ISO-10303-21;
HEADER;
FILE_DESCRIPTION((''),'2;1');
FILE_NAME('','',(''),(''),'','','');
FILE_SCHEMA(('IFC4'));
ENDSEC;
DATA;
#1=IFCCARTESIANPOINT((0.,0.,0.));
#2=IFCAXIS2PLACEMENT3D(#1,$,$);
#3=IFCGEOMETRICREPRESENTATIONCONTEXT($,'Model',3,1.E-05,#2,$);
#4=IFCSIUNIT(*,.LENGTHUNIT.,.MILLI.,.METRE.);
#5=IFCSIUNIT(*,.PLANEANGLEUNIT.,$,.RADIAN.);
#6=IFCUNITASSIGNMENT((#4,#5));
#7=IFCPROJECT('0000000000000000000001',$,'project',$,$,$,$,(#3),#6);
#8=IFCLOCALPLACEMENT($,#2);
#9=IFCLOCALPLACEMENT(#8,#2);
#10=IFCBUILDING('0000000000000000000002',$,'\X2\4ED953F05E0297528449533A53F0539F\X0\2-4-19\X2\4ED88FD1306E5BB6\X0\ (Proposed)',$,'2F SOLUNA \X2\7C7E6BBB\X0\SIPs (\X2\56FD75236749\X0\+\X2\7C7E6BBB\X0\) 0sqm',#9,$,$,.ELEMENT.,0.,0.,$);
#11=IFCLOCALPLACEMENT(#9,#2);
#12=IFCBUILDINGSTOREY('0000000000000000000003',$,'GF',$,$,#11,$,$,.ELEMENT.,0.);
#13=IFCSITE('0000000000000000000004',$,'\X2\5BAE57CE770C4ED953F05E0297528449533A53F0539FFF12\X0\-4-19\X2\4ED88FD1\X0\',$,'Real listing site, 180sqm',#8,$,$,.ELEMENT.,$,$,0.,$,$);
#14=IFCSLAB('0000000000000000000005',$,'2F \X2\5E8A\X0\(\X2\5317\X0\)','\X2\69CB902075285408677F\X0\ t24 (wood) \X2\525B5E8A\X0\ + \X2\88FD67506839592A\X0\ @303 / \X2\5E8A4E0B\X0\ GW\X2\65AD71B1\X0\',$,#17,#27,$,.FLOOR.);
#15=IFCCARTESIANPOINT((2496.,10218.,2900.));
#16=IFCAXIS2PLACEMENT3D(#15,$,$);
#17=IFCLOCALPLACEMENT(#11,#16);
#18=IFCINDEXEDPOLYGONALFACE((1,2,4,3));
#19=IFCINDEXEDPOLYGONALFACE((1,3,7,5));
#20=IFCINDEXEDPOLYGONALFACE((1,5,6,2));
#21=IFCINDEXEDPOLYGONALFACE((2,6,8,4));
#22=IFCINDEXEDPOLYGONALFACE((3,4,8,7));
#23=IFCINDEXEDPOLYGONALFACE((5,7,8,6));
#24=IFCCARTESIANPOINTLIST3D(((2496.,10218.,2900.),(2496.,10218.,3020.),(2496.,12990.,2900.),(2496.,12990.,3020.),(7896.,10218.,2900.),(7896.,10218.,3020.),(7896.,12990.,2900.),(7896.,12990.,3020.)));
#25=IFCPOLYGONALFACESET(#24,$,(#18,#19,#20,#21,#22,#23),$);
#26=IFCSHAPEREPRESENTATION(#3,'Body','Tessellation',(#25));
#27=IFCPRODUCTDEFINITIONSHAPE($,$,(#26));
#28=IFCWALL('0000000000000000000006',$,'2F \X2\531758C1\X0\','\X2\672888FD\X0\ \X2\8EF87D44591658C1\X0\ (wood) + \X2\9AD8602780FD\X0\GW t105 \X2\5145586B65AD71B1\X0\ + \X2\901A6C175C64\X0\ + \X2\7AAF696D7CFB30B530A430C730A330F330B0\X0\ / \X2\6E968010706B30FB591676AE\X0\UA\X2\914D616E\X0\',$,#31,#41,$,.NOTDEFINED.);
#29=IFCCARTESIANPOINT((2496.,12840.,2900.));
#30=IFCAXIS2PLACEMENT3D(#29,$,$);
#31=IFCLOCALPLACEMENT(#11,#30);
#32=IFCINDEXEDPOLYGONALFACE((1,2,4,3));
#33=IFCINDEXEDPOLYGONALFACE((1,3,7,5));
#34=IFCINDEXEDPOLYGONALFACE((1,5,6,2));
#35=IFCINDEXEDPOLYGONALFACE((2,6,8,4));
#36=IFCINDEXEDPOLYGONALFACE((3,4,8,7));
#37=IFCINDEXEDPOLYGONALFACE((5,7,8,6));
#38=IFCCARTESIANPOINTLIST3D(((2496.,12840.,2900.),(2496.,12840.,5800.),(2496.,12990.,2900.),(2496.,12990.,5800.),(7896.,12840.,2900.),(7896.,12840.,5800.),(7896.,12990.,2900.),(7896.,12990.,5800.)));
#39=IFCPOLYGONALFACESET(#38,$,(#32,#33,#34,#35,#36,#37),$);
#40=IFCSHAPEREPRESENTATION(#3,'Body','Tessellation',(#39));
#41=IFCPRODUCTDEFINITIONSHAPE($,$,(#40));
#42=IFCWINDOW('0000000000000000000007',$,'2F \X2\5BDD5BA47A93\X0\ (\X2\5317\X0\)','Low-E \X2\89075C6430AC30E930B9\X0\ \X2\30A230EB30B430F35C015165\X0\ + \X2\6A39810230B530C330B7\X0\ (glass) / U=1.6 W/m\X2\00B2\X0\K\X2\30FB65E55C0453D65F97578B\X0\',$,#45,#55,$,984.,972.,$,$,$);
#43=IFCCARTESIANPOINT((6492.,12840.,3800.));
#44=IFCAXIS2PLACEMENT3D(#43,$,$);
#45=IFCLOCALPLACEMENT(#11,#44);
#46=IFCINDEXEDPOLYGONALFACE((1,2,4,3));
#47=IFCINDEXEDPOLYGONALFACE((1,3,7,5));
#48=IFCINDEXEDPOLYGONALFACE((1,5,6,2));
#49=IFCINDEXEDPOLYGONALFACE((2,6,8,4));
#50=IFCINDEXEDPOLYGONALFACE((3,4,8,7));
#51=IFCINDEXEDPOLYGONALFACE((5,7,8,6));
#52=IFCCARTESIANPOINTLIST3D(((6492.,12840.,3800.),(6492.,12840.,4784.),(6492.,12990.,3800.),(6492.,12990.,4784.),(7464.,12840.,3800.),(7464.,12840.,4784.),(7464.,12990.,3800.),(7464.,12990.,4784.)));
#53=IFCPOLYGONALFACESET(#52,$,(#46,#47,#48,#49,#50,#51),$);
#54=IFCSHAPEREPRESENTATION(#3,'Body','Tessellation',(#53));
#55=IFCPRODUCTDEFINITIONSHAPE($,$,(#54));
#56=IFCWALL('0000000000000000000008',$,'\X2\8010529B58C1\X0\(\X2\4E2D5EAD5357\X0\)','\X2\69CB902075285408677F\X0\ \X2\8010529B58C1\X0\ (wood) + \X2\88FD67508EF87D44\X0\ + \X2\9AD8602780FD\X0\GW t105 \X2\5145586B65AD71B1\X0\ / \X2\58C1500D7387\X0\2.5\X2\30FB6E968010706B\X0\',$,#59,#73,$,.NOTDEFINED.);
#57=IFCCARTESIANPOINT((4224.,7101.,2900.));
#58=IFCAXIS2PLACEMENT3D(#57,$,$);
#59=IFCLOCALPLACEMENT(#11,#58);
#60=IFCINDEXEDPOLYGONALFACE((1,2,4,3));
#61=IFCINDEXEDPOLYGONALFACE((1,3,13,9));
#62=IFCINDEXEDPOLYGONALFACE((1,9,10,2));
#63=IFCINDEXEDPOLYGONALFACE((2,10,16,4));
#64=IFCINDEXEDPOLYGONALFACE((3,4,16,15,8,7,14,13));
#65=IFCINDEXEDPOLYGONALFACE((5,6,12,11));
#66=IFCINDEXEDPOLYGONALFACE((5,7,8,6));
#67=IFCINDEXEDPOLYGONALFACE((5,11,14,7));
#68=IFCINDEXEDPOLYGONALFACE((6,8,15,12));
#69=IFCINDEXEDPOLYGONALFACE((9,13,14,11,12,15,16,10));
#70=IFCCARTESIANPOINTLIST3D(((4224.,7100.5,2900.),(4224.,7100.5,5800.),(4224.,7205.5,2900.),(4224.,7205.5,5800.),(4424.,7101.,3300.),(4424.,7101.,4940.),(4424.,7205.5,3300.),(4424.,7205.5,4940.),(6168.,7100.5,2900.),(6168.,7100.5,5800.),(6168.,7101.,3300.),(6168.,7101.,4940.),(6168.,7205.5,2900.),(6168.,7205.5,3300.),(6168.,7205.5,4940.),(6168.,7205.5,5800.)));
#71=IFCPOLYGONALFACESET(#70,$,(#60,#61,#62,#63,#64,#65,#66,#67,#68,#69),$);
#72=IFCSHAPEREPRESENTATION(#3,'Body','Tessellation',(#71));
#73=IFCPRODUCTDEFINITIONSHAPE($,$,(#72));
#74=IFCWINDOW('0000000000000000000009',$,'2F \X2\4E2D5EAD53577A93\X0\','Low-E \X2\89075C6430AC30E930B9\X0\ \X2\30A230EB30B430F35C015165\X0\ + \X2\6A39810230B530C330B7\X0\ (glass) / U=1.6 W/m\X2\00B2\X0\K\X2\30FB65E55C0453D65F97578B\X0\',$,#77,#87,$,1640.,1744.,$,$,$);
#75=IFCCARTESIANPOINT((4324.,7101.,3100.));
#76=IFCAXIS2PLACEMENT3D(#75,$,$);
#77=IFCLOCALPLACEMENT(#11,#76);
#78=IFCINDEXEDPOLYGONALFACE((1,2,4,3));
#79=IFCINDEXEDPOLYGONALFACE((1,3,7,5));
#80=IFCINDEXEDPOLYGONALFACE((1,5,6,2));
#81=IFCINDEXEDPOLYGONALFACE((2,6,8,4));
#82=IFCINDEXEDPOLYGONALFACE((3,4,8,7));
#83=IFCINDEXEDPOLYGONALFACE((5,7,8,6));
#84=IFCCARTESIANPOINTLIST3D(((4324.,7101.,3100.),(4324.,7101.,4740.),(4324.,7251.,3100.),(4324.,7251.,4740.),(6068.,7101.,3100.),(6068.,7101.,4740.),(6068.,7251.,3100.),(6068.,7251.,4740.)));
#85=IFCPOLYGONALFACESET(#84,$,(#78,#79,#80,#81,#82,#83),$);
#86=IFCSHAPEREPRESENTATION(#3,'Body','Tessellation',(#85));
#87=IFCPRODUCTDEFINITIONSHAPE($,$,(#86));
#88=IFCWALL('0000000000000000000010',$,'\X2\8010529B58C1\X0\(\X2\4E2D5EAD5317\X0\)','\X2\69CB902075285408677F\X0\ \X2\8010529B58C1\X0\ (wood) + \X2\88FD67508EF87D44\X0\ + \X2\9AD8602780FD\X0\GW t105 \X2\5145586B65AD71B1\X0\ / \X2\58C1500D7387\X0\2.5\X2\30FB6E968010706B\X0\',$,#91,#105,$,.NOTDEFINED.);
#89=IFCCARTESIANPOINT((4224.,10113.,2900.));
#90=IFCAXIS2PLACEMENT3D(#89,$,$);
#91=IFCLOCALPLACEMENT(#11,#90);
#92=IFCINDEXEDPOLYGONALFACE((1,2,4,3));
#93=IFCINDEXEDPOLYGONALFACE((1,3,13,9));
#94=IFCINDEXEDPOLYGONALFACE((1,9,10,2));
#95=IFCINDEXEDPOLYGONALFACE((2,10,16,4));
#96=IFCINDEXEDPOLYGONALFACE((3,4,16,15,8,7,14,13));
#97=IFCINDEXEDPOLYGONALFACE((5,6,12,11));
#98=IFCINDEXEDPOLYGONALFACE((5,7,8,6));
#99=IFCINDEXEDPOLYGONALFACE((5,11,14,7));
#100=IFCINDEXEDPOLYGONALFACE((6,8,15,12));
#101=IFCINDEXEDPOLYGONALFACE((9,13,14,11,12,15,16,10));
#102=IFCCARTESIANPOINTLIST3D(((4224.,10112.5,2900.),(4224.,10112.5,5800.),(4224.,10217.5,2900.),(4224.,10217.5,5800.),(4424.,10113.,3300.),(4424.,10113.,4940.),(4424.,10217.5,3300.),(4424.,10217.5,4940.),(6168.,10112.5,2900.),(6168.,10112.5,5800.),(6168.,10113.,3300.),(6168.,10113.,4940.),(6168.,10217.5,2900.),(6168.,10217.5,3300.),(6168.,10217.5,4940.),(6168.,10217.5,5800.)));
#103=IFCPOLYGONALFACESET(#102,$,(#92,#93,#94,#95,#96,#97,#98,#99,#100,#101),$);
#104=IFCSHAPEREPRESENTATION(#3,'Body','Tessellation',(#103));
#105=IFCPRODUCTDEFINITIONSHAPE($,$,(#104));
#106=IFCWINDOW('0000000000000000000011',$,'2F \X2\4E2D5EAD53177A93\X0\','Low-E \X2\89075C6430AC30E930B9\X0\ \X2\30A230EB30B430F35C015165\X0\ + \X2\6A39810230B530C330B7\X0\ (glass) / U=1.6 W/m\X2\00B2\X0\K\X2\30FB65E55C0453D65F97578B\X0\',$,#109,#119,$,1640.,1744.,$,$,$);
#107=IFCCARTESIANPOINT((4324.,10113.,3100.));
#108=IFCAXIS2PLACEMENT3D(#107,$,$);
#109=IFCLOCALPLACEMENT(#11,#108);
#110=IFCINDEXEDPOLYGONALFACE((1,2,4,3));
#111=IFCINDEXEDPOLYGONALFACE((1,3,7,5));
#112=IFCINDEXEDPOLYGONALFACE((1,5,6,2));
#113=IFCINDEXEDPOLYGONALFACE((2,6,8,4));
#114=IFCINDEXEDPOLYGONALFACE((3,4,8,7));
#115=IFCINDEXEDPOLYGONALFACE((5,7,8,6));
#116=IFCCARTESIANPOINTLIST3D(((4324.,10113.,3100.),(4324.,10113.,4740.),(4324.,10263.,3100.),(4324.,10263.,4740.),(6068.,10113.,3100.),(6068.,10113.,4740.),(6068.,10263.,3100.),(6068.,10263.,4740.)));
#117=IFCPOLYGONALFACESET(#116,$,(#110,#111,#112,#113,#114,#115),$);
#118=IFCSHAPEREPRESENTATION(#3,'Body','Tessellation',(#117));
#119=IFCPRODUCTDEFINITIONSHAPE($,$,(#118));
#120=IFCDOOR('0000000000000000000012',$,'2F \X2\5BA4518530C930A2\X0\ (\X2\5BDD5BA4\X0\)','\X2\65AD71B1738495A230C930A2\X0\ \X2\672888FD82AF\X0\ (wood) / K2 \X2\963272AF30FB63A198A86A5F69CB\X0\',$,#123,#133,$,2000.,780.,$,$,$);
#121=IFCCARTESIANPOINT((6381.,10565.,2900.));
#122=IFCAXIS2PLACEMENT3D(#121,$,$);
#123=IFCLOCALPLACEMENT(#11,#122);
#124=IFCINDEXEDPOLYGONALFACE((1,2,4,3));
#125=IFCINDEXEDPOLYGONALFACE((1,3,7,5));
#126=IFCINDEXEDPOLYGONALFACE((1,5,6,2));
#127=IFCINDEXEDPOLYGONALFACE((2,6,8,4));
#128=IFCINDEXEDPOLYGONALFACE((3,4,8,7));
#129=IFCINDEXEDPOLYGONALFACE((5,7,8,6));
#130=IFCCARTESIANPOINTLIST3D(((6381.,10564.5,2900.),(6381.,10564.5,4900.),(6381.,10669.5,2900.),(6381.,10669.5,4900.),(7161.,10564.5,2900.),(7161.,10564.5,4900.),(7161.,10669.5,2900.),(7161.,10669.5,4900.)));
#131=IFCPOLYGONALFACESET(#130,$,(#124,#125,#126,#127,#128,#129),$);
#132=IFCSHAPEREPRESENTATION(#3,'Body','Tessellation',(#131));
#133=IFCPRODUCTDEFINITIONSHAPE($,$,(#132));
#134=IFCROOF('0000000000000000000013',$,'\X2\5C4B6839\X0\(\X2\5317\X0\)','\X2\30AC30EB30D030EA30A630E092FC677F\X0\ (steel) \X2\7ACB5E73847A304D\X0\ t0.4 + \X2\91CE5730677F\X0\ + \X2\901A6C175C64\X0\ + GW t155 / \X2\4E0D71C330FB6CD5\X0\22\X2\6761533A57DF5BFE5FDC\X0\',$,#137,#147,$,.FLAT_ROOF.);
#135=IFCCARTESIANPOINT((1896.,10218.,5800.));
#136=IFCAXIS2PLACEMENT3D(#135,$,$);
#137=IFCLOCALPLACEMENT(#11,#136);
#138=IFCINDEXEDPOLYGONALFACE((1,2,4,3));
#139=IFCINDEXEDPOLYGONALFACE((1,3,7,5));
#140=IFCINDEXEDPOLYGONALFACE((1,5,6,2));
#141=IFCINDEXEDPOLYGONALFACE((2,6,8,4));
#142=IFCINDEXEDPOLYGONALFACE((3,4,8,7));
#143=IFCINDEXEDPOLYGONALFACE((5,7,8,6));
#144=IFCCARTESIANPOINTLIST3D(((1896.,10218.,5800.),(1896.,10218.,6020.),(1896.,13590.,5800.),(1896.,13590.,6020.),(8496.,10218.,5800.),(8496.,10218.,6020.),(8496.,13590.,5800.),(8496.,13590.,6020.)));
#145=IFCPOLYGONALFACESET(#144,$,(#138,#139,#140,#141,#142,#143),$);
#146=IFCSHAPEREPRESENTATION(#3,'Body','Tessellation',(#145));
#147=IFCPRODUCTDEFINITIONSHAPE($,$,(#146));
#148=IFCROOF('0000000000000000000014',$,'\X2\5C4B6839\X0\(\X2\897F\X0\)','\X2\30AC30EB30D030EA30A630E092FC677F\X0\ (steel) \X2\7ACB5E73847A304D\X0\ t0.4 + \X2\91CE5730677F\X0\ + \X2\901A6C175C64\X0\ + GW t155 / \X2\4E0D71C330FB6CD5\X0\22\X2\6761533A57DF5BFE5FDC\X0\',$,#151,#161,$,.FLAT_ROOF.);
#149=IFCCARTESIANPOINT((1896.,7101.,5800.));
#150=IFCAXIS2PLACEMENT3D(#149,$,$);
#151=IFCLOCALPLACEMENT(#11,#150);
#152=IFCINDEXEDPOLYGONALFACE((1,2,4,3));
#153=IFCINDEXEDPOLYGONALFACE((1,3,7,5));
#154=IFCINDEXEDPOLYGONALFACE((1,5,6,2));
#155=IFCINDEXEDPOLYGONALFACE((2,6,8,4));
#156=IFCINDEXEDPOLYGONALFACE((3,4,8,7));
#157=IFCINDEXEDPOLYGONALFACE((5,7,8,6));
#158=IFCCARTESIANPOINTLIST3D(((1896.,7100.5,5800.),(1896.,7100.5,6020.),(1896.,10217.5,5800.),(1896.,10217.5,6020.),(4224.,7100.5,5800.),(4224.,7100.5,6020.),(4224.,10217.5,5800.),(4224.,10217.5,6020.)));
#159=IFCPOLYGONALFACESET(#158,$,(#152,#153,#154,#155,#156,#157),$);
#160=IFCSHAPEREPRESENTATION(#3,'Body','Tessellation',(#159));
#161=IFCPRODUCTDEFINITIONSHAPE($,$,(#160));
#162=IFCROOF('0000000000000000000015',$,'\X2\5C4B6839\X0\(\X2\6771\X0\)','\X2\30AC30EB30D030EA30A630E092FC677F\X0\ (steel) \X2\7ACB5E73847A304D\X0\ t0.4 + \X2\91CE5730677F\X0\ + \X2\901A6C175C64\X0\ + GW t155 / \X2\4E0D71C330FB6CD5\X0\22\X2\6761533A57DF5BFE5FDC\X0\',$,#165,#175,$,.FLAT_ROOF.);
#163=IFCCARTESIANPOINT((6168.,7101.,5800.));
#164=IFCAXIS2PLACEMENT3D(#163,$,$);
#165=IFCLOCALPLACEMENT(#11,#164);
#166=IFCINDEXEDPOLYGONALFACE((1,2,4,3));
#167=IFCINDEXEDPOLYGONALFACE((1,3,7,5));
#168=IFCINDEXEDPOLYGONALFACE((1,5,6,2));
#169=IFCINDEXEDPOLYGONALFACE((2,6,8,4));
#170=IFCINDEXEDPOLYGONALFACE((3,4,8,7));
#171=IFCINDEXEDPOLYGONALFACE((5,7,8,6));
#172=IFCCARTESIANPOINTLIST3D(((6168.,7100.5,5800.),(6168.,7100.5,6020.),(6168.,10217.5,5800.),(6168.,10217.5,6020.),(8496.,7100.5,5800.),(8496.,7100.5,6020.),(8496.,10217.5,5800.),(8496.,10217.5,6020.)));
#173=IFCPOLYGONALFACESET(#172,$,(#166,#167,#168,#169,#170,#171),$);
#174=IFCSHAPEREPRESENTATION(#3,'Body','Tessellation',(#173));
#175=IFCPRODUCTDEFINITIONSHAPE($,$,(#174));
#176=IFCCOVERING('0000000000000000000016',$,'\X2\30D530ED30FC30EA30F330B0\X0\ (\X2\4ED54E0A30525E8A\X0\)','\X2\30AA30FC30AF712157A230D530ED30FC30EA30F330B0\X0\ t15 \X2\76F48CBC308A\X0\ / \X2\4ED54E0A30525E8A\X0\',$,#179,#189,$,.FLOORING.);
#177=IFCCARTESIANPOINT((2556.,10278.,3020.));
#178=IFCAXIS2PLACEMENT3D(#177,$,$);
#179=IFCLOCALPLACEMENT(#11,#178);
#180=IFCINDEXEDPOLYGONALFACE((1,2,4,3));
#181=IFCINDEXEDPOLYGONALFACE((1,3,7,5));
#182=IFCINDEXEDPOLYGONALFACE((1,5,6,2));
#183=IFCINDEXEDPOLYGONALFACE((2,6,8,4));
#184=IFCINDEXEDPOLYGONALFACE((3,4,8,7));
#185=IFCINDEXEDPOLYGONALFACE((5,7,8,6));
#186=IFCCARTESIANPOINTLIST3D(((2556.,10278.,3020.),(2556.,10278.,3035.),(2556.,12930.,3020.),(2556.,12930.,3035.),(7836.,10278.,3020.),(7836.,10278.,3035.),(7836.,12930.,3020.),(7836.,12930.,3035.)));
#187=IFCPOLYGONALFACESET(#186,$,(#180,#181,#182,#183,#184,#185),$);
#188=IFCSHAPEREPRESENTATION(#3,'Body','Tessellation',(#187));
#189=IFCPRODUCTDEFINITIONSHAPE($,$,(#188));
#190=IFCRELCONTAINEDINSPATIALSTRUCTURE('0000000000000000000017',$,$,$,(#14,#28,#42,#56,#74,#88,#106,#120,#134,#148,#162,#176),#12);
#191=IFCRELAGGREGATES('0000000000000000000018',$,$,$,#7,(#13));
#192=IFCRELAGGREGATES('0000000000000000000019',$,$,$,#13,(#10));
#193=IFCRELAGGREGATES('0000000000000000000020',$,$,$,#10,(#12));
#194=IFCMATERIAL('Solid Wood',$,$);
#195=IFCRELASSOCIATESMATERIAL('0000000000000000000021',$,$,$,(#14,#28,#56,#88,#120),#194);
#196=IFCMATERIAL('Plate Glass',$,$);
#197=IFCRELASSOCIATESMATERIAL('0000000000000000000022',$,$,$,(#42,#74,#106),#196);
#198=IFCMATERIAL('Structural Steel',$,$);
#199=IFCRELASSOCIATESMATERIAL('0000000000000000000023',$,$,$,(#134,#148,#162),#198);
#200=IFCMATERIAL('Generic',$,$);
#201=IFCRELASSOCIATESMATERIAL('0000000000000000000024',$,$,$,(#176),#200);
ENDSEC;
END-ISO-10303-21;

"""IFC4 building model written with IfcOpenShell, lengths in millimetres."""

from ifc_helpers import new_model, si_unit, frame, frame_2d, origin, place, context, project, spatial, rectangle, extrude, material, element, fill, save


model = new_model("IFC4")

# Units and contexts
model_context = context("Model", 3, precision=1e-05, world=origin())
ifc_project = project(units=[si_unit("LENGTHUNIT", "METRE", prefix="MILLI"), si_unit("PLANEANGLEUNIT", "RADIAN")], contexts=[model_context])

# Site, building, storey
site_placement = place(None, origin())
site = spatial("IfcSite", under=ifc_project, at=site_placement, Name="宮城県仙台市青葉区台原２-4-19付近", ObjectType="Real listing site, 180sqm", CompositionType="ELEMENT", RefElevation=0.0)
building_placement = place(site_placement, origin())
building = spatial("IfcBuilding", under=site, at=building_placement, Name="仙台市青葉区台原2-4-19付近の家 (Proposed)", ObjectType="2F SOLUNA 籾殻SIPs (国産杉+籾殻) 0sqm", CompositionType="ELEMENT", ElevationOfRefHeight=0.0, ElevationOfTerrain=0.0)
storey_placement = place(building_placement, origin())
storey = spatial("IfcBuildingStorey", under=building, at=storey_placement, Name="GF", CompositionType="ELEMENT", Elevation=0.0)

# Slab
ifc_material_1 = material(Name="Solid Wood")
slab_placement = place(storey_placement, frame((2496.0, 10218.0, 2900.0)))
element("IfcSlab", 1, at=slab_placement, inside=storey, material=ifc_material_1, Name="2F 床(北)", Description="構造用合板 t24 (wood) 剛床 + 製材根太 @303 / 床下 GW断熱", PredefinedType="FLOOR", context=model_context, shape_type="SweptSolid", body=[
    extrude(rectangle(XDim=5400.0, YDim=2772.0, at=frame_2d((2700.0, 1386.0))), frame((2496.0, 10218.0, 2900.0)), (0.0, 0.0, 1.0), 120.0),
])

# Walls, openings, windows
wall_1_placement = place(storey_placement, frame((2496.0, 12840.0, 2900.0)))
wall_1 = element("IfcWall", 2, at=wall_1_placement, inside=storey, material=ifc_material_1, Name="2F 北壁", Description="木製 軸組外壁 (wood) + 高性能GW t105 充填断熱 + 通気層 + 窯業系サイディング / 準耐火・外皮UA配慮", PredefinedType="NOTDEFINED", context=model_context, shape_type="SweptSolid", body=[
    extrude(rectangle(XDim=5400.0, YDim=150.0, at=frame_2d((2700.0, 75.0))), frame((2496.0, 12840.0, 2900.0)), (0.0, 0.0, 1.0), 2900.0),
])
opening_1_placement = place(storey_placement, frame((6492.0, 12840.0, 3800.0)))
opening_1 = element("IfcOpeningElement", 3, at=opening_1_placement, cuts=wall_1, PredefinedType="NOTDEFINED", context=model_context, shape_type="SweptSolid", body=[
    extrude(rectangle(XDim=972.0, YDim=150.0, at=frame_2d((486.0, 75.0))), frame((6492.0, 12840.0, 3800.0)), (0.0, 0.0, 1.0), 984.0),
])
ifc_material_2 = material(Name="Plate Glass")
window_1_placement = place(storey_placement, frame((6492.0, 12840.0, 3800.0)))
window_1 = element("IfcWindow", 4, at=window_1_placement, inside=storey, material=ifc_material_2, Name="2F 寝室窓 (北)", Description="Low-E 複層ガラス アルゴン封入 + 樹脂サッシ (glass) / U=1.6 W/m²K・日射取得型", OverallHeight=984.0, OverallWidth=972.0, context=model_context, shape_type="SweptSolid", body=[
    extrude(rectangle(XDim=972.0, YDim=150.0, at=frame_2d((486.0, 75.0))), frame((6492.0, 12840.0, 3800.0)), (0.0, 0.0, 1.0), 984.0),
])
fill(opening_1, window_1)
wall_2_placement = place(storey_placement, frame((4224.0, 7101.0, 2900.0)))
wall_2 = element("IfcWall", 5, at=wall_2_placement, inside=storey, material=ifc_material_1, Name="耐力壁(中庭南)", Description="構造用合板 耐力壁 (wood) + 製材軸組 + 高性能GW t105 充填断熱 / 壁倍率2.5・準耐火", PredefinedType="NOTDEFINED", context=model_context, shape_type="SweptSolid", body=[
    extrude(rectangle(XDim=1944.0, YDim=105.0, at=frame_2d((972.0, 52.0))), frame((4224.0, 7101.0, 2900.0)), (0.0, 0.0, 1.0), 2900.0),
])
opening_2_placement = place(storey_placement, frame((4324.0, 7101.0, 3100.0)))
opening_2 = element("IfcOpeningElement", 6, at=opening_2_placement, cuts=wall_2, PredefinedType="NOTDEFINED", context=model_context, shape_type="SweptSolid", body=[
    extrude(rectangle(XDim=1744.0, YDim=150.0, at=frame_2d((872.0, 75.0))), frame((4324.0, 7101.0, 3100.0)), (0.0, 0.0, 1.0), 1640.0),
])
window_2_placement = place(storey_placement, frame((4324.0, 7101.0, 3100.0)))
window_2 = element("IfcWindow", 7, at=window_2_placement, inside=storey, material=ifc_material_2, Name="2F 中庭南窓", Description="Low-E 複層ガラス アルゴン封入 + 樹脂サッシ (glass) / U=1.6 W/m²K・日射取得型", OverallHeight=1640.0, OverallWidth=1744.0, context=model_context, shape_type="SweptSolid", body=[
    extrude(rectangle(XDim=1744.0, YDim=150.0, at=frame_2d((872.0, 75.0))), frame((4324.0, 7101.0, 3100.0)), (0.0, 0.0, 1.0), 1640.0),
])
fill(opening_2, window_2)
wall_3_placement = place(storey_placement, frame((4224.0, 10113.0, 2900.0)))
wall_3 = element("IfcWall", 8, at=wall_3_placement, inside=storey, material=ifc_material_1, Name="耐力壁(中庭北)", Description="構造用合板 耐力壁 (wood) + 製材軸組 + 高性能GW t105 充填断熱 / 壁倍率2.5・準耐火", PredefinedType="NOTDEFINED", context=model_context, shape_type="SweptSolid", body=[
    extrude(rectangle(XDim=1944.0, YDim=105.0, at=frame_2d((972.0, 52.0))), frame((4224.0, 10113.0, 2900.0)), (0.0, 0.0, 1.0), 2900.0),
])
opening_3_placement = place(storey_placement, frame((4324.0, 10113.0, 3100.0)))
opening_3 = element("IfcOpeningElement", 9, at=opening_3_placement, cuts=wall_3, PredefinedType="NOTDEFINED", context=model_context, shape_type="SweptSolid", body=[
    extrude(rectangle(XDim=1744.0, YDim=150.0, at=frame_2d((872.0, 75.0))), frame((4324.0, 10113.0, 3100.0)), (0.0, 0.0, 1.0), 1640.0),
])
window_3_placement = place(storey_placement, frame((4324.0, 10113.0, 3100.0)))
window_3 = element("IfcWindow", 10, at=window_3_placement, inside=storey, material=ifc_material_2, Name="2F 中庭北窓", Description="Low-E 複層ガラス アルゴン封入 + 樹脂サッシ (glass) / U=1.6 W/m²K・日射取得型", OverallHeight=1640.0, OverallWidth=1744.0, context=model_context, shape_type="SweptSolid", body=[
    extrude(rectangle(XDim=1744.0, YDim=150.0, at=frame_2d((872.0, 75.0))), frame((4324.0, 10113.0, 3100.0)), (0.0, 0.0, 1.0), 1640.0),
])
fill(opening_3, window_3)

# Door
door_placement = place(storey_placement, frame((6381.0, 10565.0, 2900.0)))
element("IfcDoor", 11, at=door_placement, inside=storey, material=ifc_material_1, Name="2F 室内ドア (寝室)", Description="断熱玄関ドア 木製芯 (wood) / K2 防犯・採風機構", OverallHeight=2000.0, OverallWidth=780.0, context=model_context, shape_type="SweptSolid", body=[
    extrude(rectangle(XDim=780.0, YDim=105.0, at=frame_2d((390.0, 52.0))), frame((6381.0, 10565.0, 2900.0)), (0.0, 0.0, 1.0), 2000.0),
])

# Roofs
ifc_material_3 = material(Name="Structural Steel")
for number, where, name in (
    (12, (1896.0, 10218.0, 5800.0), "屋根(北)"),
):
    element("IfcRoof", number, at=place(storey_placement, frame(where)), inside=storey, material=ifc_material_3, Name=name, Description="ガルバリウム鋼板 (steel) 立平葺き t0.4 + 野地板 + 通気層 + GW t155 / 不燃・法22条区域対応", PredefinedType="FLAT_ROOF", context=model_context, shape_type="SweptSolid", body=[
        extrude(rectangle(XDim=6600.0, YDim=3372.0, at=frame_2d((3300.0, 1686.0))), frame((1896.0, 10218.0, 5800.0)), (0.0, 0.0, 1.0), 220.0),
    ])
roof_1_placement = place(storey_placement, frame((1896.0, 7101.0, 5800.0)))
element("IfcRoof", 13, at=roof_1_placement, inside=storey, material=ifc_material_3, Name="屋根(西)", Description="ガルバリウム鋼板 (steel) 立平葺き t0.4 + 野地板 + 通気層 + GW t155 / 不燃・法22条区域対応", PredefinedType="FLAT_ROOF", context=model_context, shape_type="SweptSolid", body=[
    extrude(rectangle(XDim=2328.0, YDim=3117.0, at=frame_2d((1164.0, 1558.0))), frame((1896.0, 7101.0, 5800.0)), (0.0, 0.0, 1.0), 220.0),
])
roof_2_placement = place(storey_placement, frame((6168.0, 7101.0, 5800.0)))
element("IfcRoof", 14, at=roof_2_placement, inside=storey, material=ifc_material_3, Name="屋根(東)", Description="ガルバリウム鋼板 (steel) 立平葺き t0.4 + 野地板 + 通気層 + GW t155 / 不燃・法22条区域対応", PredefinedType="FLAT_ROOF", context=model_context, shape_type="SweptSolid", body=[
    extrude(rectangle(XDim=2328.0, YDim=3117.0, at=frame_2d((1164.0, 1558.0))), frame((6168.0, 7101.0, 5800.0)), (0.0, 0.0, 1.0), 220.0),
])

# Covering
ifc_material_4 = material(Name="Generic")
covering_1_placement = place(storey_placement, frame((2556.0, 10278.0, 3020.0)))
element("IfcCovering", 15, at=covering_1_placement, inside=storey, material=ifc_material_4, Name="フローリング (仕上げ床)", Description="オーク無垢フローリング t15 直貼り / 仕上げ床", PredefinedType="FLOORING", context=model_context, shape_type="SweptSolid", body=[
    extrude(rectangle(XDim=5280.0, YDim=2652.0, at=frame_2d((2640.0, 1326.0))), frame((2556.0, 10278.0, 3020.0)), (0.0, 0.0, 1.0), 15.0),
])

save(model, "model.ifc")
